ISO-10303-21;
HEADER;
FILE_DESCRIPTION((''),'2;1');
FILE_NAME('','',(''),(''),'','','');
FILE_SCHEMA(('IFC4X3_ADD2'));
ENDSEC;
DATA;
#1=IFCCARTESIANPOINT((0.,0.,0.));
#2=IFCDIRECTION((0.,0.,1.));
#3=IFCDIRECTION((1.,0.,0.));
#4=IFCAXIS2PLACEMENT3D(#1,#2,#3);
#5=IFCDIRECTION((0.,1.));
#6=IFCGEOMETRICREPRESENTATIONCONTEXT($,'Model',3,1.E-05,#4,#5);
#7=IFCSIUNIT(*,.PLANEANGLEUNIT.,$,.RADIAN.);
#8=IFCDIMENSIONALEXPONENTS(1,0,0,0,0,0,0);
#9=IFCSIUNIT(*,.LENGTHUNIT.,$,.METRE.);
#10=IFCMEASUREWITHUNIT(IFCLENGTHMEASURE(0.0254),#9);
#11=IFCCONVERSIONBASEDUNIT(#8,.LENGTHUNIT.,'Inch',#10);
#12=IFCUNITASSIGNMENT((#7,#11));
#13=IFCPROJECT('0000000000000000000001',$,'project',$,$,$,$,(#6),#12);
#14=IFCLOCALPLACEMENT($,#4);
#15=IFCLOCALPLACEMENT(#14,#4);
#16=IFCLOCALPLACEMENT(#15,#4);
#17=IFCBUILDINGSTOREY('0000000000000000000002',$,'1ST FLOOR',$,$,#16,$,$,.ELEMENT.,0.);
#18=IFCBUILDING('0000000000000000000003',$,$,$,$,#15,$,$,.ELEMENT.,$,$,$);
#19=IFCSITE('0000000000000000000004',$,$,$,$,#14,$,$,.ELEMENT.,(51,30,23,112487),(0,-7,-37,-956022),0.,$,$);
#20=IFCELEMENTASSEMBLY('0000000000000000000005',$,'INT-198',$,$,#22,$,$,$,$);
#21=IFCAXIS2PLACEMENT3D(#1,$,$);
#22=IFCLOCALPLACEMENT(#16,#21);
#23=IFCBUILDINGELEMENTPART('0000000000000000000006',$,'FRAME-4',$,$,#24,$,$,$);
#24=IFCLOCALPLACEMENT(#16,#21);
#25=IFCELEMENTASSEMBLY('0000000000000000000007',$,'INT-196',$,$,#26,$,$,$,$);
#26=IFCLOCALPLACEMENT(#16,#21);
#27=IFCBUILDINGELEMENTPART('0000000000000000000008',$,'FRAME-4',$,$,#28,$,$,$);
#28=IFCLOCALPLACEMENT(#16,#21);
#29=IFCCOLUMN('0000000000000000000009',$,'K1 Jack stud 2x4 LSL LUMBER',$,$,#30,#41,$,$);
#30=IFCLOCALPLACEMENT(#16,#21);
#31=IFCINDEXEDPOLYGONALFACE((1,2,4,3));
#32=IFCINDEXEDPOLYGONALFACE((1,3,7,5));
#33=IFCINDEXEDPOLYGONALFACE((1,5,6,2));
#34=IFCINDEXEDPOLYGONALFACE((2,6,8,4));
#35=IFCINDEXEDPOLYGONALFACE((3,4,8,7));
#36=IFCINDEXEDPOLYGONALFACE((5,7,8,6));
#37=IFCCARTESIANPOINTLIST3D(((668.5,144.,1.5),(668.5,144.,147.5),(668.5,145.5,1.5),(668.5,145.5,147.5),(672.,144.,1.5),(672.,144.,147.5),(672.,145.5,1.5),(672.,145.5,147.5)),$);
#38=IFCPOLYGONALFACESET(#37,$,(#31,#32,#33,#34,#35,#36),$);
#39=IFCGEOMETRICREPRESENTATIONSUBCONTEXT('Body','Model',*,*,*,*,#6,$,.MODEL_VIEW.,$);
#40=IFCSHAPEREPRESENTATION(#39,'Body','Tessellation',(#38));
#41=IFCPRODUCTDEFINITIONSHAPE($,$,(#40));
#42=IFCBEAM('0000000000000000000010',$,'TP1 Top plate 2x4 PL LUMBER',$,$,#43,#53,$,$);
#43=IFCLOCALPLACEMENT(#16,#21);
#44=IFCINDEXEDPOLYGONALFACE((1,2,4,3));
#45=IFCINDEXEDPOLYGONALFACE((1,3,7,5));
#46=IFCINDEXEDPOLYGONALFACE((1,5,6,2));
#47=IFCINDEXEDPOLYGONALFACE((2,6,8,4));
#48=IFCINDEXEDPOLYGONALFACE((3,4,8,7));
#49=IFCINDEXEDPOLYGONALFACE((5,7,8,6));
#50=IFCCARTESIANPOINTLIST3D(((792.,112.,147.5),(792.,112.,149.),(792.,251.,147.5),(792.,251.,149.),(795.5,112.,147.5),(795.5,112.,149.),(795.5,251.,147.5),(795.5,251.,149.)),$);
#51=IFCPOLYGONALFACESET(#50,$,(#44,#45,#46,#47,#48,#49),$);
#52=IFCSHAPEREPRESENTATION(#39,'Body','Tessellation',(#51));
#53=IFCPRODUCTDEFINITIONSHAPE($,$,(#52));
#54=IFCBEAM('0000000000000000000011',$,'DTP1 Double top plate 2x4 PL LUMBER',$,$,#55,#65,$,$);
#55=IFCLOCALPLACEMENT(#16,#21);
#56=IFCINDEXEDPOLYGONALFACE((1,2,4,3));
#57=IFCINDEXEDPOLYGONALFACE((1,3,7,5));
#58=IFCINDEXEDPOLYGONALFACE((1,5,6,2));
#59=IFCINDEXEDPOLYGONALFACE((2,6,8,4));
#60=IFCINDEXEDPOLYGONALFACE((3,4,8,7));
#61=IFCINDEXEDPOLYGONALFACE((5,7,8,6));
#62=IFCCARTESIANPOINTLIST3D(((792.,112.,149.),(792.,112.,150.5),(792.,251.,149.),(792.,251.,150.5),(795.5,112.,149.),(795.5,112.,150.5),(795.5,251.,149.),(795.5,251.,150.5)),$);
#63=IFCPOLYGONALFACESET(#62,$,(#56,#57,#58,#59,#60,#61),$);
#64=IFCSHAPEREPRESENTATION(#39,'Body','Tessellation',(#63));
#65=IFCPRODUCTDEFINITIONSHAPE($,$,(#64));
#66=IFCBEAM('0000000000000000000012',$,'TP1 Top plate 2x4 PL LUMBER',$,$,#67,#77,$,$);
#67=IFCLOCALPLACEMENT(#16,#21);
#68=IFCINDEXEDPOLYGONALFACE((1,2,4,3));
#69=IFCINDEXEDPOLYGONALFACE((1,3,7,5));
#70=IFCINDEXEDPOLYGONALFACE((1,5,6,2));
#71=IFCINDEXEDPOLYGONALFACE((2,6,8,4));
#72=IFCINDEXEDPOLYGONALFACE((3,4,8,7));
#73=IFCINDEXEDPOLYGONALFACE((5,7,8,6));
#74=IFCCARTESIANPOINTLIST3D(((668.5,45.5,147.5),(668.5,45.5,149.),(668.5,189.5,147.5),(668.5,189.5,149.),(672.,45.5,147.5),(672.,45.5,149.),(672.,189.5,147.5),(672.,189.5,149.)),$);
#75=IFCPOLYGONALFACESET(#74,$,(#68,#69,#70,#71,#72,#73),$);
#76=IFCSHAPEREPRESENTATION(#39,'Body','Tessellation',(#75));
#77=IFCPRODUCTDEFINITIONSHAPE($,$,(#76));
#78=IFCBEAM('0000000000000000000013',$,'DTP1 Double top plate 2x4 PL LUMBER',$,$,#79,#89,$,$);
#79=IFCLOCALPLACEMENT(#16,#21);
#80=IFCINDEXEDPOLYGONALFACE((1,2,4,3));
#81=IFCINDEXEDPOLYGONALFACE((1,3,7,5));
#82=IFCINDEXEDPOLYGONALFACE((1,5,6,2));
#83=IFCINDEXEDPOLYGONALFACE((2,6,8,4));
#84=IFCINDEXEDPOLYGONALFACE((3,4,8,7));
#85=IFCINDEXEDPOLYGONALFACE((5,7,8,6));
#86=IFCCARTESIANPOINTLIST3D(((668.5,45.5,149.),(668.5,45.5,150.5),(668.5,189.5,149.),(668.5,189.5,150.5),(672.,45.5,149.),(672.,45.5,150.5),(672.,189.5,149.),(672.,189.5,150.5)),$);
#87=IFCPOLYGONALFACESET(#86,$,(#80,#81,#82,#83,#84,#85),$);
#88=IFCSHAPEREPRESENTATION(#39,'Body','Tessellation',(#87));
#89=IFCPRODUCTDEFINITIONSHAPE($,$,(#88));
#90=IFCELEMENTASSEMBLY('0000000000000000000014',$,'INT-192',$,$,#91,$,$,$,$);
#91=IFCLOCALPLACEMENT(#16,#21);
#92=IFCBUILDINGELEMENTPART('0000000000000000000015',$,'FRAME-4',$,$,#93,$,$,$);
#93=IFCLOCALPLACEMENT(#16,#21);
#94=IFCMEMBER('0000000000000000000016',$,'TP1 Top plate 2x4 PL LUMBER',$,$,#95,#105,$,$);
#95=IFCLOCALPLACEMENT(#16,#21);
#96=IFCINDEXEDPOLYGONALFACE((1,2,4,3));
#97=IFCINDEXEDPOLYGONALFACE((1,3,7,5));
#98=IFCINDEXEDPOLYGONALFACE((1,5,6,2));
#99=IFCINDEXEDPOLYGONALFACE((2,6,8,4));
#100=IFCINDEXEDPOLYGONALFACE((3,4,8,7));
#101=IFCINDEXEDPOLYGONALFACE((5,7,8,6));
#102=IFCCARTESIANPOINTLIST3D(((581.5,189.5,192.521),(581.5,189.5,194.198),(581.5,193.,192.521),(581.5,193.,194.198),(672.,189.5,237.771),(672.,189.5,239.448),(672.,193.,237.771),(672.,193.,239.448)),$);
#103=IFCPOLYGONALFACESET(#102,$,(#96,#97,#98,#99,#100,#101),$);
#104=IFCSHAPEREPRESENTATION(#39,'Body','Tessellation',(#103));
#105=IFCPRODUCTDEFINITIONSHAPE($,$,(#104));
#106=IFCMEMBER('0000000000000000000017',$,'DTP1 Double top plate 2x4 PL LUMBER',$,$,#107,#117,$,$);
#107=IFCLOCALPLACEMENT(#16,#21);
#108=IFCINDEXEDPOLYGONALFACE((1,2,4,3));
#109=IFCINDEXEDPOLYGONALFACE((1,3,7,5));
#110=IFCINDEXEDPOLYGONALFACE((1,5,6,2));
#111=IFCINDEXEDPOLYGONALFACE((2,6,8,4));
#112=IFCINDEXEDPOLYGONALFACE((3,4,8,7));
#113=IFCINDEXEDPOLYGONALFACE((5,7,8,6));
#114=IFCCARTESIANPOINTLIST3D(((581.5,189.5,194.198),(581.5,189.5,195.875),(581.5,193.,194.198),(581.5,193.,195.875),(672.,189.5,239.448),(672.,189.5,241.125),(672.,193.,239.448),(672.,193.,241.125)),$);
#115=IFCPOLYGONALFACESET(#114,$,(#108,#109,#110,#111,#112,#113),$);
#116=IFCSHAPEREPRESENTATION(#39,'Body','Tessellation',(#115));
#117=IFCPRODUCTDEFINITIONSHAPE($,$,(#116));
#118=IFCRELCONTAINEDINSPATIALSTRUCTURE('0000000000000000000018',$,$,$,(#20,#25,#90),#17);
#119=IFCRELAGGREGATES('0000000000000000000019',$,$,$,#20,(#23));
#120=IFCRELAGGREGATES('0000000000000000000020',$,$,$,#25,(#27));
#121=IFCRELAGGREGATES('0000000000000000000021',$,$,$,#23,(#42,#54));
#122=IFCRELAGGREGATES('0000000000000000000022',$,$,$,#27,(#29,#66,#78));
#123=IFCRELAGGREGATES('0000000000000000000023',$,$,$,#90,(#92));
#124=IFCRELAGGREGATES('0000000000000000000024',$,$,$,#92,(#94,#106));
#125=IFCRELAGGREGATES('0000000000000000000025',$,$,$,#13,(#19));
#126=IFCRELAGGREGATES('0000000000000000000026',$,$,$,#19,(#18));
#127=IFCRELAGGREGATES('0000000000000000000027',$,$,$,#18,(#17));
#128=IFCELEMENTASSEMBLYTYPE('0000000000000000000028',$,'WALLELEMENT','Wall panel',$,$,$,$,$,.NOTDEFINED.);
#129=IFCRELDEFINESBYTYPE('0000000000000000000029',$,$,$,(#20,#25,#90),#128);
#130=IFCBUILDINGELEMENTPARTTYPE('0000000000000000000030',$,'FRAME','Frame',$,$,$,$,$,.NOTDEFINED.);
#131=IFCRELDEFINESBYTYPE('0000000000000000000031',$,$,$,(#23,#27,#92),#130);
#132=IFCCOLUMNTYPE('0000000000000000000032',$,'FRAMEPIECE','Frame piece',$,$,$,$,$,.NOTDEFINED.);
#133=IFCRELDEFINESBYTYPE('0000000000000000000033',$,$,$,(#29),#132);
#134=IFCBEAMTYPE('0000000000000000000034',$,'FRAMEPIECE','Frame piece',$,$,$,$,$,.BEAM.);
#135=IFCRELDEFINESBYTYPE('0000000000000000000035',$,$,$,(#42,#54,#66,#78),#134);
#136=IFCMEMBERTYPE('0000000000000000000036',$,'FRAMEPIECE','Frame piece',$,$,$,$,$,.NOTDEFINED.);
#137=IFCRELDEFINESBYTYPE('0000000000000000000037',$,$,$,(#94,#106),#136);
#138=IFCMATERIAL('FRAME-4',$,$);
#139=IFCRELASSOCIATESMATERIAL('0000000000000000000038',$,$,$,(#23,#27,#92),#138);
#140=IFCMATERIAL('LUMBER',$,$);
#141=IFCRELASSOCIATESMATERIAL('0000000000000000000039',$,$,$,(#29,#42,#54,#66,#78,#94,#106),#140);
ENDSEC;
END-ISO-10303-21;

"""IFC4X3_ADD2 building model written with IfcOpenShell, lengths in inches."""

from ifc_helpers import new_model, entity, si_unit, converted_unit, direction, frame, origin_with_axes, origin_2d_with_axis, place, context, subcontext, project, spatial, rectangle, extrude, clip, halfspace, material, type_object, element, aggregate, save


model = new_model("IFC4X3_ADD2")

# Units and contexts
model_context = context("Model", 3, precision=1e-05, world=origin_with_axes(), true_north=direction((0.0, 1.0)))
body_context = subcontext(model_context, "Body", "Model", "MODEL_VIEW")
ifc_project = project(units=[si_unit("PLANEANGLEUNIT", "RADIAN"), converted_unit("LENGTHUNIT", "Inch", entity("IfcLengthMeasure", 0.0254), si_unit("LENGTHUNIT", "METRE"), dimensions=[1, 0, 0, 0, 0, 0, 0])], contexts=[model_context])

# Site, building, storey
site_placement = place(None, origin_with_axes())
site = spatial("IfcSite", under=ifc_project, at=site_placement, CompositionType="ELEMENT", RefLatitude=(51, 30, 23, 112487), RefLongitude=(0, -7, -37, -956022), RefElevation=0.0)
building_placement = place(site_placement, origin_with_axes())
building = spatial("IfcBuilding", under=site, at=building_placement, CompositionType="ELEMENT")
storey_placement = place(building_placement, origin_with_axes())
storey = spatial("IfcBuildingStorey", under=building, at=storey_placement, Name="1ST FLOOR", CompositionType="ELEMENT", Elevation=0.0)

# Element assemblies, building element parts, column
element_assembly_type = type_object("IfcElementAssemblyType", Name="WALLELEMENT", Description="Wall panel", PredefinedType="NOTDEFINED")
ifc_material_1 = material(Name="FRAME-4")
building_element_part_type = type_object("IfcBuildingElementPartType", Name="FRAME", Description="Frame", PredefinedType="NOTDEFINED")
ifc_material_2 = material(Name="LUMBER")
column_type = type_object("IfcColumnType", Name="FRAMEPIECE", Description="Frame piece", PredefinedType="NOTDEFINED")
assembly_1_placement = place(storey_placement, origin_with_axes())
assembly_1 = element("IfcElementAssembly", 1, at=assembly_1_placement, inside=storey, type_object=element_assembly_type, Name="INT-198")
building_element_part_1_placement = place(storey_placement, origin_with_axes())
building_element_part_1 = element("IfcBuildingElementPart", 2, at=building_element_part_1_placement, type_object=building_element_part_type, material=ifc_material_1, Name="FRAME-4")
aggregate(assembly_1, [building_element_part_1])
assembly_2_placement = place(storey_placement, origin_with_axes())
assembly_2 = element("IfcElementAssembly", 3, at=assembly_2_placement, inside=storey, type_object=element_assembly_type, Name="INT-196")
building_element_part_2_placement = place(storey_placement, origin_with_axes())
building_element_part_2 = element("IfcBuildingElementPart", 4, at=building_element_part_2_placement, type_object=building_element_part_type, material=ifc_material_1, Name="FRAME-4")
aggregate(assembly_2, [building_element_part_2])
column_1_placement = place(storey_placement, frame((670.25, 144.75, 147.5), z_axis=(0.0, 0.0, -1.0), x_axis=(0.0, 1.0, 0.0)))
column_1 = element("IfcColumn", 5, at=column_1_placement, type_object=column_type, material=ifc_material_2, Name="K1 Jack stud 2x4 LSL LUMBER", context=body_context, shape_type="SweptSolid", body=[
    extrude(rectangle(XDim=1.5, YDim=3.5, at=origin_2d_with_axis()), origin_with_axes(), (0.0, 0.0, 1.0), 146.0),
])

# Beams
beam_type = type_object("IfcBeamType", Name="FRAMEPIECE", Description="Frame piece", PredefinedType="BEAM")
beam_1_placement = place(storey_placement, frame((793.75, 112.0, 148.25), z_axis=(0.0, 1.0, 0.0), x_axis=(0.0, 0.0, -1.0)))
beam_1 = element("IfcBeam", 6, at=beam_1_placement, type_object=beam_type, material=ifc_material_2, Name="TP1 Top plate 2x4 PL LUMBER", context=body_context, shape_type="SweptSolid", body=[
    extrude(rectangle(XDim=1.5, YDim=3.5, at=origin_2d_with_axis()), origin_with_axes(), (0.0, 0.0, 1.0), 139.0),
])
beam_2_placement = place(storey_placement, frame((793.75, 112.0, 149.75), z_axis=(0.0, 1.0, 0.0), x_axis=(0.0, 0.0, -1.0)))
beam_2 = element("IfcBeam", 7, at=beam_2_placement, type_object=beam_type, material=ifc_material_2, Name="DTP1 Double top plate 2x4 PL LUMBER", context=body_context, shape_type="SweptSolid", body=[
    extrude(rectangle(XDim=1.5, YDim=3.5, at=origin_2d_with_axis()), origin_with_axes(), (0.0, 0.0, 1.0), 139.0),
])
aggregate(building_element_part_1, [beam_1, beam_2])
beam_3_placement = place(storey_placement, frame((670.25, 189.5, 148.25), z_axis=(0.0, -1.0, 0.0), x_axis=(0.0, 0.0, -1.0)))
beam_3 = element("IfcBeam", 8, at=beam_3_placement, type_object=beam_type, material=ifc_material_2, Name="TP1 Top plate 2x4 PL LUMBER", context=body_context, shape_type="SweptSolid", body=[
    extrude(rectangle(XDim=1.5, YDim=3.5, at=origin_2d_with_axis()), origin_with_axes(), (0.0, 0.0, 1.0), 144.0),
])
beam_4_placement = place(storey_placement, frame((670.25, 189.5, 149.75), z_axis=(0.0, -1.0, 0.0), x_axis=(0.0, 0.0, -1.0)))
beam_4 = element("IfcBeam", 9, at=beam_4_placement, type_object=beam_type, material=ifc_material_2, Name="DTP1 Double top plate 2x4 PL LUMBER", context=body_context, shape_type="SweptSolid", body=[
    extrude(rectangle(XDim=1.5, YDim=3.5, at=origin_2d_with_axis()), origin_with_axes(), (0.0, 0.0, 1.0), 144.0),
])
aggregate(building_element_part_2, [column_1, beam_3, beam_4])

# Element assembly, building element part, members
assembly_3_placement = place(storey_placement, origin_with_axes())
assembly_3 = element("IfcElementAssembly", 10, at=assembly_3_placement, inside=storey, type_object=element_assembly_type, Name="INT-192")
building_element_part_3_placement = place(storey_placement, origin_with_axes())
building_element_part_3 = element("IfcBuildingElementPart", 11, at=building_element_part_3_placement, type_object=building_element_part_type, material=ifc_material_1, Name="FRAME-4")
aggregate(assembly_3, [building_element_part_3])
member_type = type_object("IfcMemberType", Name="FRAMEPIECE", Description="Frame piece", PredefinedType="NOTDEFINED")
member_1_placement = place(storey_placement, frame((672.335, 191.25, 238.777), z_axis=(-0.894427, 0.0, -0.447214), x_axis=(0.447214, 0.0, -0.894427)))
member_1 = element("IfcMember", 12, at=member_1_placement, type_object=member_type, material=ifc_material_2, Name="TP1 Top plate 2x4 PL LUMBER", context=body_context, shape_type="CSG", body=[
    clip(clip(extrude(rectangle(XDim=1.5, YDim=3.5, at=origin_2d_with_axis()), origin_with_axes(), (0.0, 0.0, 1.0), 101.932), halfspace(frame((0.0, 0.0, 0.375), z_axis=(0.447214, 0.0, -0.894427), x_axis=(0.0, 1.0, 0.0)), False)), halfspace(frame((0.0, 0.0, 101.557), z_axis=(-0.447214, 0.0, 0.894427), x_axis=(0.0, -1.0, 0.0)), False)),
])
member_2_placement = place(storey_placement, frame((672.336, 191.25, 240.454), z_axis=(-0.894427, 0.0, -0.447214), x_axis=(0.447214, 0.0, -0.894427)))
member_2 = element("IfcMember", 13, at=member_2_placement, type_object=member_type, material=ifc_material_2, Name="DTP1 Double top plate 2x4 PL LUMBER", context=body_context, shape_type="CSG", body=[
    clip(clip(extrude(rectangle(XDim=1.5, YDim=3.5, at=origin_2d_with_axis()), origin_with_axes(), (0.0, 0.0, 1.0), 101.932), halfspace(frame((0.0, 0.0, 0.375), z_axis=(0.447214, 0.0, -0.894427), x_axis=(0.894427, 0.0, 0.447214)), False)), halfspace(frame((0.0, 0.0, 101.557), z_axis=(-0.447214, 0.0, 0.894427), x_axis=(-0.894427, 0.0, -0.447214)), False)),
])
aggregate(building_element_part_3, [member_1, member_2])

save(model, "model.ifc")
